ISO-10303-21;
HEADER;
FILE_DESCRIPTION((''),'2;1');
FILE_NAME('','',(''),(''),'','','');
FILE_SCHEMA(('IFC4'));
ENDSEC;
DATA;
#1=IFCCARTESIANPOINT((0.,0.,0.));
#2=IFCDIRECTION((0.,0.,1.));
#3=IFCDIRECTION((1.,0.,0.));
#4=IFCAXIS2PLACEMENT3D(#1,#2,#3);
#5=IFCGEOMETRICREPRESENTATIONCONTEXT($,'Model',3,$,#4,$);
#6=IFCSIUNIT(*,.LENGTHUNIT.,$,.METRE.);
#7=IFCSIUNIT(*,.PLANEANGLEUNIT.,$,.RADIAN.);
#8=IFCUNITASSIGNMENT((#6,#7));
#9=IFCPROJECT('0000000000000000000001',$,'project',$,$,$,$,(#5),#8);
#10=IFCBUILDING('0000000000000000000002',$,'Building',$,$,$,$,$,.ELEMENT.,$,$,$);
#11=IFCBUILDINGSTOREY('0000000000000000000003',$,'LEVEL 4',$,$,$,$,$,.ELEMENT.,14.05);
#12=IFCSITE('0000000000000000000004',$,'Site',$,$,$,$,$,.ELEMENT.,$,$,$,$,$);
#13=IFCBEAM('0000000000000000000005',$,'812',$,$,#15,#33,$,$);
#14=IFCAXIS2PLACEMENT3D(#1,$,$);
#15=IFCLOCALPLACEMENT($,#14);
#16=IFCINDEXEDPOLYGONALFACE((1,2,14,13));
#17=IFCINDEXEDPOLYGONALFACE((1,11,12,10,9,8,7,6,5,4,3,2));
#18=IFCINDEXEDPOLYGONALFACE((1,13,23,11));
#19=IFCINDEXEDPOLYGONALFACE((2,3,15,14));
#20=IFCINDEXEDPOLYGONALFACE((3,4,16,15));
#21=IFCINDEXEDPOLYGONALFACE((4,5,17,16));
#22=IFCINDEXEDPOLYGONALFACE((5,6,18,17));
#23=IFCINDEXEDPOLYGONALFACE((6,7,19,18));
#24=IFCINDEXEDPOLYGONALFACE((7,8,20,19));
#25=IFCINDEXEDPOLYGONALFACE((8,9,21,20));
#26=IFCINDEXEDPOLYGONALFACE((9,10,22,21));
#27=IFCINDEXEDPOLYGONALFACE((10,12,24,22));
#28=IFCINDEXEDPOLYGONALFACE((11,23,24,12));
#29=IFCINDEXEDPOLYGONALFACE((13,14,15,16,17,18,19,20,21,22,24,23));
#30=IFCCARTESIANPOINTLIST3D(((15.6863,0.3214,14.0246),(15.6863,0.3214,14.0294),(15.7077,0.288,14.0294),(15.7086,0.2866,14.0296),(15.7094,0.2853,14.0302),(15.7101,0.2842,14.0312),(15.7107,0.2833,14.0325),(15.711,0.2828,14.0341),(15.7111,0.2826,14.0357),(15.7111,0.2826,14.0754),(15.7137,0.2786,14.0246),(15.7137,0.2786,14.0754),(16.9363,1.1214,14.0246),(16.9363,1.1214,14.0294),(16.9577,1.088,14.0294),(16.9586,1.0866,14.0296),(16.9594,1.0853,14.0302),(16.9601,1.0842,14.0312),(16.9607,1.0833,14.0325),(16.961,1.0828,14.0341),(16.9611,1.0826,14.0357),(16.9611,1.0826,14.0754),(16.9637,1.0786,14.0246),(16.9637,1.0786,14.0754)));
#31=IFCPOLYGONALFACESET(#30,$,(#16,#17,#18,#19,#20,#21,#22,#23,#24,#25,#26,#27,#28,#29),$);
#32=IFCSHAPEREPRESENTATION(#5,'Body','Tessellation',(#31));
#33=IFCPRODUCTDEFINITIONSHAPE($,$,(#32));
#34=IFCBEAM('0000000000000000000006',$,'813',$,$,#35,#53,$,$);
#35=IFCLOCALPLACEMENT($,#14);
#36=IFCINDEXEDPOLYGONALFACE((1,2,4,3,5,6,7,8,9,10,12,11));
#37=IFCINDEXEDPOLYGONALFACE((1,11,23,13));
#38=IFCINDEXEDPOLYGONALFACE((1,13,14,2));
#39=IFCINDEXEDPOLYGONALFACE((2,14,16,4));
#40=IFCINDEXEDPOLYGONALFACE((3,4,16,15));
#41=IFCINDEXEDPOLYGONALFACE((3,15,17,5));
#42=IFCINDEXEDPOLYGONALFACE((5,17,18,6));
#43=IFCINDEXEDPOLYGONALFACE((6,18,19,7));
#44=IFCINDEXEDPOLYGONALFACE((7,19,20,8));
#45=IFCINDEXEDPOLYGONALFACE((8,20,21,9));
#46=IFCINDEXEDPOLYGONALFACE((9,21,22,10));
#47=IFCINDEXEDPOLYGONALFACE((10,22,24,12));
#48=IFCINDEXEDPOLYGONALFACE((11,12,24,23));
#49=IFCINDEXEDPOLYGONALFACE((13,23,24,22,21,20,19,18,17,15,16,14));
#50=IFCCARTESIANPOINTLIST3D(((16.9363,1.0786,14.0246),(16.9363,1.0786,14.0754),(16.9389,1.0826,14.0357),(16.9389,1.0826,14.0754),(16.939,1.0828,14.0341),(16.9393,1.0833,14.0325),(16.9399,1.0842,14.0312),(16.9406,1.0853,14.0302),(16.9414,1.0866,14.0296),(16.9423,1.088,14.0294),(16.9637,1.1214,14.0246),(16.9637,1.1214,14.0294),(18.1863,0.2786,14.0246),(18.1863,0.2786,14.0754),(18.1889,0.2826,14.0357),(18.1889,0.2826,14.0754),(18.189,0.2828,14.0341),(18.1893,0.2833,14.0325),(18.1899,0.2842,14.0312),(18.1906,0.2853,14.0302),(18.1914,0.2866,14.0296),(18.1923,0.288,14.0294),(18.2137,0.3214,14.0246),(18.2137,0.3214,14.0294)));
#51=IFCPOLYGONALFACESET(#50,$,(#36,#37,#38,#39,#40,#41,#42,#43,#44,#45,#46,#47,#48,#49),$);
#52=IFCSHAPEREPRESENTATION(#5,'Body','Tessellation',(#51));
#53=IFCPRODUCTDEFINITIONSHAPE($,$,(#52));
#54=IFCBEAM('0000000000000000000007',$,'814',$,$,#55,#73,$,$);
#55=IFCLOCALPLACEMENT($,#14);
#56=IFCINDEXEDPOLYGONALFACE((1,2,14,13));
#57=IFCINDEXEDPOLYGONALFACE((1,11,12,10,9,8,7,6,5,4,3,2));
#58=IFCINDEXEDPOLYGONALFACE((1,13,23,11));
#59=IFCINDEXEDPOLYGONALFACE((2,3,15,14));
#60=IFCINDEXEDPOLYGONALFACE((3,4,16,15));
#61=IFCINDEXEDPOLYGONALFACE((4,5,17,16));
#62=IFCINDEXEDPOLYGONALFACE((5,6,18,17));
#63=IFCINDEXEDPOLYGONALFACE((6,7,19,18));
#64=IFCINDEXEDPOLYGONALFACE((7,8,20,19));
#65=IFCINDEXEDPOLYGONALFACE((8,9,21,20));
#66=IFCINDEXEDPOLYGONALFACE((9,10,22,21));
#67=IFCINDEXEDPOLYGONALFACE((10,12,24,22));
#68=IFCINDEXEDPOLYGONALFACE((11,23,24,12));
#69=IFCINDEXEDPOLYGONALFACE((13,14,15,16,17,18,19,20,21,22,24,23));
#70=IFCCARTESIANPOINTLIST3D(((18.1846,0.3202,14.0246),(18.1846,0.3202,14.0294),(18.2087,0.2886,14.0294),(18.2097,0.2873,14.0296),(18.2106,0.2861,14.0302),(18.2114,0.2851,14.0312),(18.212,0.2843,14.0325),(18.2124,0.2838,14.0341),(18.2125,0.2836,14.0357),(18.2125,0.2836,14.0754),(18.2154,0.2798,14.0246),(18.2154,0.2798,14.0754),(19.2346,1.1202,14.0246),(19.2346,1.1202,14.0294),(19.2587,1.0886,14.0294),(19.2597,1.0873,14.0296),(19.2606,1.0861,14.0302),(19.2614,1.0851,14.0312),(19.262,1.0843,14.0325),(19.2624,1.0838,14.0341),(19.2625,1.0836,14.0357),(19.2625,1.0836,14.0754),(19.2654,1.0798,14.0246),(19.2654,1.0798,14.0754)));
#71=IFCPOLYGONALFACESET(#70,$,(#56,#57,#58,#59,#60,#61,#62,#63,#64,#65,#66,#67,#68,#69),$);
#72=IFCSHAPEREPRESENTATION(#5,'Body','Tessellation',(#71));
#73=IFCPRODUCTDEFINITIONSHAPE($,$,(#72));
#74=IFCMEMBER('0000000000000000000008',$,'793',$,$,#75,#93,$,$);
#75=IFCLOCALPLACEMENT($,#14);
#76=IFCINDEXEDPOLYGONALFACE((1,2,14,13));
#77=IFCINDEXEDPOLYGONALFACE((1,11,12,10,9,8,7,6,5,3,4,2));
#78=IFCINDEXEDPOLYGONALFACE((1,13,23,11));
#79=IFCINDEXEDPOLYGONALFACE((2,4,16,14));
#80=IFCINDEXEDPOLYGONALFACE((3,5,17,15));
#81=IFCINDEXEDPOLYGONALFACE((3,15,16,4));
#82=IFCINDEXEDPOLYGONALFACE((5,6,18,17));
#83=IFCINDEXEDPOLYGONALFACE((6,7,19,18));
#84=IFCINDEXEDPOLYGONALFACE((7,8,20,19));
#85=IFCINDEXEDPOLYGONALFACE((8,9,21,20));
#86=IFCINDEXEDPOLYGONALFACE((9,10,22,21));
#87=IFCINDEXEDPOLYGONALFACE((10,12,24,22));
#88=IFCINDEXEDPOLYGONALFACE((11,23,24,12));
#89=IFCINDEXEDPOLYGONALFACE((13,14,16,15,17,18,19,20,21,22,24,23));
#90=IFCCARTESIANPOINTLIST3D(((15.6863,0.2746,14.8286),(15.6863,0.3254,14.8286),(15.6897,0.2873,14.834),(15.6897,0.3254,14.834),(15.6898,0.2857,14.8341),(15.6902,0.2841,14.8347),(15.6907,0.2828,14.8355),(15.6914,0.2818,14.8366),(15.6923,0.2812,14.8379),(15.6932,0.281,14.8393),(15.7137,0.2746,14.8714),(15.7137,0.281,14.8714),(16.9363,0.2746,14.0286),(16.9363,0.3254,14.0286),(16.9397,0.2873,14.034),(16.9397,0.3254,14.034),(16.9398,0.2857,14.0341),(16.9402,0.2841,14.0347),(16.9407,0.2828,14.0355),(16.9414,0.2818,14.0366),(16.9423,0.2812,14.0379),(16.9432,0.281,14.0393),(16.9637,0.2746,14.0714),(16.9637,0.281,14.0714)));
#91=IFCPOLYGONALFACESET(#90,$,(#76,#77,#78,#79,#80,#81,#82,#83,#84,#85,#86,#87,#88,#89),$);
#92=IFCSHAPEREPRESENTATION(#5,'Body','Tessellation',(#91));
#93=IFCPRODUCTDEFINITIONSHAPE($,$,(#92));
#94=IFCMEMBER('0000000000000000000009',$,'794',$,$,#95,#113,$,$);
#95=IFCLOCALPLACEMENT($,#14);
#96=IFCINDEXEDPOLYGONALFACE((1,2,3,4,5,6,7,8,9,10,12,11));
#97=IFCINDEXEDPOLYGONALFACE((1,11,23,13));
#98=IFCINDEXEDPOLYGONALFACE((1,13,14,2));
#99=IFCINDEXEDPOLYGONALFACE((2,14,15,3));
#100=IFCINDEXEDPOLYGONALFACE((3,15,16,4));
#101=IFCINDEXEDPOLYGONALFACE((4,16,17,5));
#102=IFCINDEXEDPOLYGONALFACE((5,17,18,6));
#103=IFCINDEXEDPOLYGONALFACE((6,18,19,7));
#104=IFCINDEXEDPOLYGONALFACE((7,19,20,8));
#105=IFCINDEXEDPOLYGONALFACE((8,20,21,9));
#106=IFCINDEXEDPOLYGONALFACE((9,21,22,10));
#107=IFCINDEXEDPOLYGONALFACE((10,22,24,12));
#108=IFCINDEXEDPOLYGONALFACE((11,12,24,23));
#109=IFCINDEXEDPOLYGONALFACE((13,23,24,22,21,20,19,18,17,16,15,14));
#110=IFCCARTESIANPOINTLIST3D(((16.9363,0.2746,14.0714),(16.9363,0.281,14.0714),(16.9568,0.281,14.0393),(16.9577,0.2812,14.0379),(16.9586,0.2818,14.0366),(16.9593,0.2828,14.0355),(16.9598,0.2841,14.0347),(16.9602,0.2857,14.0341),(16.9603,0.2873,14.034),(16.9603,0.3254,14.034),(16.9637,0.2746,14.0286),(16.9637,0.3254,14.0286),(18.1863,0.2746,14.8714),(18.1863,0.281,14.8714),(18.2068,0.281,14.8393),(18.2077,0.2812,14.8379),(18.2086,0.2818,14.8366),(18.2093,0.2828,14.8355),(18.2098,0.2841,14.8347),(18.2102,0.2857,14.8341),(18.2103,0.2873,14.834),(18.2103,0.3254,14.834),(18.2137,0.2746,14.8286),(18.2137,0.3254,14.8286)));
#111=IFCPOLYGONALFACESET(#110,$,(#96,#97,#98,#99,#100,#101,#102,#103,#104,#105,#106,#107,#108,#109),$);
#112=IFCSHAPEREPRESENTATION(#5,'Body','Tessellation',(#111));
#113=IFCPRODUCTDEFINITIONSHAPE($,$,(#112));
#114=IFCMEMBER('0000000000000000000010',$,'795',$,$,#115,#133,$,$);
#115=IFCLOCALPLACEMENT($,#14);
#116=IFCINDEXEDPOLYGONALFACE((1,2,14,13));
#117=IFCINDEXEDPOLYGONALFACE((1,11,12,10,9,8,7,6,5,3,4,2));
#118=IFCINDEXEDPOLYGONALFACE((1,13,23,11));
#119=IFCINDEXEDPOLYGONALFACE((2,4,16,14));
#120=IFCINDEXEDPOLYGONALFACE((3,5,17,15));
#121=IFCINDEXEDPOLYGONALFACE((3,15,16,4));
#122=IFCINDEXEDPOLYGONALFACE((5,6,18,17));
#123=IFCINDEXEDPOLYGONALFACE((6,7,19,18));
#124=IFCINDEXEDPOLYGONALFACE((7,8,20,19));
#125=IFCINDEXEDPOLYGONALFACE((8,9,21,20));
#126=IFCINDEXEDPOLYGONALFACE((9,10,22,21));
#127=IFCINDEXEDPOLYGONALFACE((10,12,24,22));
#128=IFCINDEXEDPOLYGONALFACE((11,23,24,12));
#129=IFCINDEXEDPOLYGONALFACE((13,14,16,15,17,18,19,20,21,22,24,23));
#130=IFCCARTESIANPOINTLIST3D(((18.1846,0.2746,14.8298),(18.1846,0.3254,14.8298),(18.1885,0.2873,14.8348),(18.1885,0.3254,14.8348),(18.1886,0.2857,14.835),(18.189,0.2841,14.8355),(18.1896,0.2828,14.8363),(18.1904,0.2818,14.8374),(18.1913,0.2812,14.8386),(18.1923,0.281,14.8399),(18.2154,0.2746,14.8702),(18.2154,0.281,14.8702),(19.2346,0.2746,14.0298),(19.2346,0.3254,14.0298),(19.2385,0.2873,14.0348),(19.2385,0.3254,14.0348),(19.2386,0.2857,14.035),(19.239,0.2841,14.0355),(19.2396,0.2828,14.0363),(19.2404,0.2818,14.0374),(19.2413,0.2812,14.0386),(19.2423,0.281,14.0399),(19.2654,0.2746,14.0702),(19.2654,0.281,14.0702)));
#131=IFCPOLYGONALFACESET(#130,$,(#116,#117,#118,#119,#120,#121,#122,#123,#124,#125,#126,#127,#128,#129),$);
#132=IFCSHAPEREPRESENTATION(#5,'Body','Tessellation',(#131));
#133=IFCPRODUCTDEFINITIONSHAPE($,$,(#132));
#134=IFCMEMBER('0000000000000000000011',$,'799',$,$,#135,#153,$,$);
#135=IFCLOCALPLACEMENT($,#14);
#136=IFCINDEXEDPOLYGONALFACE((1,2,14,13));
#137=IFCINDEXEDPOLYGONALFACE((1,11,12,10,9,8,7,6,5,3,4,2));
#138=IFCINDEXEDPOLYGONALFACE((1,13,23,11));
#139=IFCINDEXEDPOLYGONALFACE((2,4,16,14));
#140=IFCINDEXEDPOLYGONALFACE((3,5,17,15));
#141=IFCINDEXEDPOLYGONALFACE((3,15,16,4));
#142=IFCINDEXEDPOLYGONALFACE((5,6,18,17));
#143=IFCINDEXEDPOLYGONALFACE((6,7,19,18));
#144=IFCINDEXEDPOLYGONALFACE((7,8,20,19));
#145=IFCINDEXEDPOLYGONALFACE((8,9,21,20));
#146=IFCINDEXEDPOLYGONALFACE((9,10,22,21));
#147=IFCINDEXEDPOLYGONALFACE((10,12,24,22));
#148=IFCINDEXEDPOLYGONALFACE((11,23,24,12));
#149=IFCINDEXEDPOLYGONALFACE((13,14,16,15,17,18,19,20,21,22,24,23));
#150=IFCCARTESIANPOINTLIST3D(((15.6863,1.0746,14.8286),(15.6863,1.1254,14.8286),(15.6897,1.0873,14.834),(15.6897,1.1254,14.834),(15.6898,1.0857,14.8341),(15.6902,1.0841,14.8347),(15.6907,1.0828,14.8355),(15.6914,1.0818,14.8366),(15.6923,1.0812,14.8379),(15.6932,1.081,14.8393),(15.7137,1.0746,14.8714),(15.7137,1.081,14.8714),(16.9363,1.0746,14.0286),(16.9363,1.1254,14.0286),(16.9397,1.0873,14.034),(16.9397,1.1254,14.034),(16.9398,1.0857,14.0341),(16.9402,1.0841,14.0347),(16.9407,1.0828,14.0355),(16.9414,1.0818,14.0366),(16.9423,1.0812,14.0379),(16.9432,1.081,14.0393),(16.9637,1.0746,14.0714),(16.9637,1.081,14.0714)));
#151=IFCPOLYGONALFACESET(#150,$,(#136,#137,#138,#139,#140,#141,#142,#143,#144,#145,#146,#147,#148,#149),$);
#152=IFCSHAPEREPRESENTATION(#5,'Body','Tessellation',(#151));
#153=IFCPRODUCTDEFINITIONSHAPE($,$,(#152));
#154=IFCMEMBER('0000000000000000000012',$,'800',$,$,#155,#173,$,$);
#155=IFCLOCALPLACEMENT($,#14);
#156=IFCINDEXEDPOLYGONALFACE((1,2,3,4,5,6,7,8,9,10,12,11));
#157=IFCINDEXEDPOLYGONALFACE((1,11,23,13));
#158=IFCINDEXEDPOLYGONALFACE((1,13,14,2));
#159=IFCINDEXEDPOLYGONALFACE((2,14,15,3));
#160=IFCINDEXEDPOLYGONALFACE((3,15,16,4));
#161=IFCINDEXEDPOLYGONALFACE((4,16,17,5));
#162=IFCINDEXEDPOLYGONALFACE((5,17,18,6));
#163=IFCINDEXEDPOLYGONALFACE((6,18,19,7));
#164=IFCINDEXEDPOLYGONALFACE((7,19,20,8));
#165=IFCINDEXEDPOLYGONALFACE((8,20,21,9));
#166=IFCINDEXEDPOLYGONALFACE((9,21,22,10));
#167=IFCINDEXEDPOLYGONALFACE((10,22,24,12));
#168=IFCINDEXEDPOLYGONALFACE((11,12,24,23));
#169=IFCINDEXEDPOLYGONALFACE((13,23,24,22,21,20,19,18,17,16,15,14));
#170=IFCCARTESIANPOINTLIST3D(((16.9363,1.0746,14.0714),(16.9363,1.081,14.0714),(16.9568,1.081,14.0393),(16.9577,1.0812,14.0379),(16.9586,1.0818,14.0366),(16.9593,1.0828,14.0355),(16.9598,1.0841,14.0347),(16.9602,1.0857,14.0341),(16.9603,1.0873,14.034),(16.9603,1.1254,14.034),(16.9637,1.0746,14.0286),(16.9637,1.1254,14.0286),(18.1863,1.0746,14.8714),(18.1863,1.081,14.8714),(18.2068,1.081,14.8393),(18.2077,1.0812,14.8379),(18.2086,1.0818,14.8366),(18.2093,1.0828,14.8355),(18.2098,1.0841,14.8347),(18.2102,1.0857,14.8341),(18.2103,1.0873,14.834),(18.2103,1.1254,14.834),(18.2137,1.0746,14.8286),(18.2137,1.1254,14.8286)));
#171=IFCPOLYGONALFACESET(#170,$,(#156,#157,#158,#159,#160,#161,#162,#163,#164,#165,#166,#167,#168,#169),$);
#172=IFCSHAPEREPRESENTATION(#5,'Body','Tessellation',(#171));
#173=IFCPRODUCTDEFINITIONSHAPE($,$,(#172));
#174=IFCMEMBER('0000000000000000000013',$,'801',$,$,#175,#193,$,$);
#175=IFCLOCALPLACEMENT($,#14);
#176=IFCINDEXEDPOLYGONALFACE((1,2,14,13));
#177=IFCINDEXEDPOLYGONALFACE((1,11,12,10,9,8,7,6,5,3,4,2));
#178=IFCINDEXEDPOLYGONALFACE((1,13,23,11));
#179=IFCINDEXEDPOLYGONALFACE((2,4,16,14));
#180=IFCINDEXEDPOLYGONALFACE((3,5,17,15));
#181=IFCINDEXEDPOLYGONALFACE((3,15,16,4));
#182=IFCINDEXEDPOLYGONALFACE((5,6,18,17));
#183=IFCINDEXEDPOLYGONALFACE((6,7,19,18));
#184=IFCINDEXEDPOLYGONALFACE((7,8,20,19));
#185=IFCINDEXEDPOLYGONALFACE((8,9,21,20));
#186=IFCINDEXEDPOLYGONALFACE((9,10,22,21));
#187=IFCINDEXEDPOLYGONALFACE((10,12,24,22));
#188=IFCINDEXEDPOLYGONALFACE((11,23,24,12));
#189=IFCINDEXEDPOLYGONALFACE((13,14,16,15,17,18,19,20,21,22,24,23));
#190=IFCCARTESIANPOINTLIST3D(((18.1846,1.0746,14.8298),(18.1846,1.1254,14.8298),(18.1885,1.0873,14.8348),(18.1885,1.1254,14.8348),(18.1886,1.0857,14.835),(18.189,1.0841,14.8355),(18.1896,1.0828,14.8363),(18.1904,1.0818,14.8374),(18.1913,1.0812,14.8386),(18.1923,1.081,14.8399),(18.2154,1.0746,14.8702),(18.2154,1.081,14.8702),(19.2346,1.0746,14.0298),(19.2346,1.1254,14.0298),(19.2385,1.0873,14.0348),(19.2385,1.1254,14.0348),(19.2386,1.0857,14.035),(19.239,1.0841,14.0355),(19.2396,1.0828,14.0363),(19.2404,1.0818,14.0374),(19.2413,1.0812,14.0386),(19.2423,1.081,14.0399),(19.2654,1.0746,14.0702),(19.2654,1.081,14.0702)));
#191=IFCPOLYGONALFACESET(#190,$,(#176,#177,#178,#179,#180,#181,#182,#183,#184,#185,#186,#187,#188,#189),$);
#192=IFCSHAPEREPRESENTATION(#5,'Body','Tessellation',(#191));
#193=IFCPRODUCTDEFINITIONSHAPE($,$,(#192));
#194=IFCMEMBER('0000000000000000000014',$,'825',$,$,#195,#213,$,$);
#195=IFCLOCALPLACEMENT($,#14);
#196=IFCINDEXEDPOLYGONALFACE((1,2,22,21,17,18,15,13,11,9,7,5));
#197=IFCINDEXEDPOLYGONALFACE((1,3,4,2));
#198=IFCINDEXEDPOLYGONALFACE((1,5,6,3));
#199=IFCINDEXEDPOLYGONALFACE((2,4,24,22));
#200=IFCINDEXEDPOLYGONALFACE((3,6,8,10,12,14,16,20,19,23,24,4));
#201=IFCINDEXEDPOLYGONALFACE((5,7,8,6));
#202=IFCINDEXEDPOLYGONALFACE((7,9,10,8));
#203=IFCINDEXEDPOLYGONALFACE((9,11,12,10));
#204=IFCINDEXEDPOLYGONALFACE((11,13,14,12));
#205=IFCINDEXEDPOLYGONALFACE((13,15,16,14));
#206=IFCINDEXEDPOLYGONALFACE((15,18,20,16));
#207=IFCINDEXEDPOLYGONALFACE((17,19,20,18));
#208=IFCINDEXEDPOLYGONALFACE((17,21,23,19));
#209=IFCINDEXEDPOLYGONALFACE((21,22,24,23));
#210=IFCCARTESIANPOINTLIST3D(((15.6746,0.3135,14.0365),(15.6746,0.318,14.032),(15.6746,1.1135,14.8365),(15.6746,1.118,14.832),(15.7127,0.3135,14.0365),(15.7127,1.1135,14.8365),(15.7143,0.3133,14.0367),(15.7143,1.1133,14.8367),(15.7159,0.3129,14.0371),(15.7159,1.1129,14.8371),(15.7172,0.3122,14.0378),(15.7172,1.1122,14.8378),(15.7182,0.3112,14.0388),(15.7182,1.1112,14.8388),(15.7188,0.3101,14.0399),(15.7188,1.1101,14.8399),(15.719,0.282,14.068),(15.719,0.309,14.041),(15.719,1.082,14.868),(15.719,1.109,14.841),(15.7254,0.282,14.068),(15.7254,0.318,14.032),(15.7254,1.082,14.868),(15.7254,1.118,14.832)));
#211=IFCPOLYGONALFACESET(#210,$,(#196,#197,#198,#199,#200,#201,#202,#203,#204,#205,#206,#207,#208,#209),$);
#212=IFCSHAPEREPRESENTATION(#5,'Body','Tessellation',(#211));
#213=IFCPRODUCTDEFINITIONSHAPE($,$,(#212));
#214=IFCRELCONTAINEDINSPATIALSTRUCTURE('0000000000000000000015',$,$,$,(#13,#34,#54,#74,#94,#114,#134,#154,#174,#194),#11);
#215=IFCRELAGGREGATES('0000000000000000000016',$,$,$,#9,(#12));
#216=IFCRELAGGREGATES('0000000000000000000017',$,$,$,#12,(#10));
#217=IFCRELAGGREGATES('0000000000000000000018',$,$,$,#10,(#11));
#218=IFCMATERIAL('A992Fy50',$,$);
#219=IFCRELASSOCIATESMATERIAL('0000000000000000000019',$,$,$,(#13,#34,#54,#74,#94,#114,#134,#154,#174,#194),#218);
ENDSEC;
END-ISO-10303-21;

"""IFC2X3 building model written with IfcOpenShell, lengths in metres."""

from ifc_helpers import new_model, si_unit, frame, origin_with_axes, origin_2d_with_axis, place, context, project, spatial, l_section, extrude, material, element, save


model = new_model("IFC2X3")

# Units and contexts
model_context = context("Model", 3, world=origin_with_axes())
ifc_project = project(units=[si_unit("LENGTHUNIT", "METRE"), si_unit("PLANEANGLEUNIT", "RADIAN")], contexts=[model_context])

# Site, building, storey
site = spatial("IfcSite", under=ifc_project, Name="Site", CompositionType="ELEMENT")
building = spatial("IfcBuilding", under=site, Name="Building", CompositionType="ELEMENT")
storey = spatial("IfcBuildingStorey", under=building, Name="LEVEL 4", CompositionType="ELEMENT", Elevation=14.05)

# Shared definitions
ifc_material = material(Name="A992Fy50")

# Beams
for number, where, z_axis, x_axis, name in (
    (1, (15.7, 0.3, 14.05), (0.842271, 0.539054, 0.0), (-0.539054, 0.842271, 0.0), "812"),
    (2, (16.95, 1.1, 14.05), (0.842271, -0.539054, 0.0), (0.539054, 0.842271, 0.0), "813"),
):
    element("IfcBeam", number, at=place(None, frame(where, z_axis=z_axis, x_axis=x_axis)), inside=storey, material=ifc_material, Name=name, context=model_context, shape_type="SweptSolid", body=[
        extrude(l_section(Depth=0.0508, Width=0.0508, Thickness=0.0048, FilletRadius=0.0063, at=origin_2d_with_axis()), origin_with_axes(), (0.0, 0.0, 1.0), 1.4841),
    ])
beam_1_placement = place(None, frame((18.2, 0.3, 14.05), z_axis=(0.795432, 0.606043, 0.0), x_axis=(-0.606043, 0.795432, 0.0)))
element("IfcBeam", 3, at=beam_1_placement, inside=storey, material=ifc_material, Name="814", context=model_context, shape_type="SweptSolid", body=[
    extrude(l_section(Depth=0.0508, Width=0.0508, Thickness=0.0048, FilletRadius=0.0063, at=origin_2d_with_axis()), origin_with_axes(), (0.0, 0.0, 1.0), 1.32),
])

# Members
for number, where, z_axis, x_axis, name in (
    (4, (15.7, 0.3, 14.85), (0.842271, 0.0, -0.539054), (0.0, 1.0, 0.0), "793"),
    (5, (16.95, 0.3, 14.05), (0.842271, 0.0, 0.539054), (0.0, 1.0, 0.0), "794"),
):
    element("IfcMember", number, at=place(None, frame(where, z_axis=z_axis, x_axis=x_axis)), inside=storey, material=ifc_material, Name=name, context=model_context, shape_type="SweptSolid", body=[
        extrude(l_section(Depth=0.0508, Width=0.0508, Thickness=0.0063, FilletRadius=0.0063, at=origin_2d_with_axis()), origin_with_axes(), (0.0, 0.0, 1.0), 1.4841),
    ])
member_1_placement = place(None, frame((18.2, 0.3, 14.85), z_axis=(0.795432, 0.0, -0.606043), x_axis=(0.0, 1.0, 0.0)))
element("IfcMember", 6, at=member_1_placement, inside=storey, material=ifc_material, Name="795", context=model_context, shape_type="SweptSolid", body=[
    extrude(l_section(Depth=0.0508, Width=0.0508, Thickness=0.0063, FilletRadius=0.0063, at=origin_2d_with_axis()), origin_with_axes(), (0.0, 0.0, 1.0), 1.32),
])
for number, where, z_axis, x_axis, name in (
    (7, (15.7, 1.1, 14.85), (0.842271, 0.0, -0.539054), (0.0, 1.0, 0.0), "799"),
    (8, (16.95, 1.1, 14.05), (0.842271, 0.0, 0.539054), (0.0, 1.0, 0.0), "800"),
):
    element("IfcMember", number, at=place(None, frame(where, z_axis=z_axis, x_axis=x_axis)), inside=storey, material=ifc_material, Name=name, context=model_context, shape_type="SweptSolid", body=[
        extrude(l_section(Depth=0.0508, Width=0.0508, Thickness=0.0063, FilletRadius=0.0063, at=origin_2d_with_axis()), origin_with_axes(), (0.0, 0.0, 1.0), 1.4841),
    ])
member_2_placement = place(None, frame((18.2, 1.1, 14.85), z_axis=(0.795432, 0.0, -0.606043), x_axis=(0.0, 1.0, 0.0)))
element("IfcMember", 9, at=member_2_placement, inside=storey, material=ifc_material, Name="801", context=model_context, shape_type="SweptSolid", body=[
    extrude(l_section(Depth=0.0508, Width=0.0508, Thickness=0.0063, FilletRadius=0.0063, at=origin_2d_with_axis()), origin_with_axes(), (0.0, 0.0, 1.0), 1.32),
])
for number, where, z_axis, x_axis, name in (
    (10, (15.7, 0.3, 14.05), (0.0, 0.707107, 0.707107), (-1.0, 0.0, 0.0), "825"),
):
    element("IfcMember", number, at=place(None, frame(where, z_axis=z_axis, x_axis=x_axis)), inside=storey, material=ifc_material, Name=name, context=model_context, shape_type="SweptSolid", body=[
        extrude(l_section(Depth=0.0508, Width=0.0508, Thickness=0.0063, FilletRadius=0.0063, at=origin_2d_with_axis()), origin_with_axes(), (0.0, 0.0, 1.0), 1.1314),
    ])

save(model, "model.ifc")
